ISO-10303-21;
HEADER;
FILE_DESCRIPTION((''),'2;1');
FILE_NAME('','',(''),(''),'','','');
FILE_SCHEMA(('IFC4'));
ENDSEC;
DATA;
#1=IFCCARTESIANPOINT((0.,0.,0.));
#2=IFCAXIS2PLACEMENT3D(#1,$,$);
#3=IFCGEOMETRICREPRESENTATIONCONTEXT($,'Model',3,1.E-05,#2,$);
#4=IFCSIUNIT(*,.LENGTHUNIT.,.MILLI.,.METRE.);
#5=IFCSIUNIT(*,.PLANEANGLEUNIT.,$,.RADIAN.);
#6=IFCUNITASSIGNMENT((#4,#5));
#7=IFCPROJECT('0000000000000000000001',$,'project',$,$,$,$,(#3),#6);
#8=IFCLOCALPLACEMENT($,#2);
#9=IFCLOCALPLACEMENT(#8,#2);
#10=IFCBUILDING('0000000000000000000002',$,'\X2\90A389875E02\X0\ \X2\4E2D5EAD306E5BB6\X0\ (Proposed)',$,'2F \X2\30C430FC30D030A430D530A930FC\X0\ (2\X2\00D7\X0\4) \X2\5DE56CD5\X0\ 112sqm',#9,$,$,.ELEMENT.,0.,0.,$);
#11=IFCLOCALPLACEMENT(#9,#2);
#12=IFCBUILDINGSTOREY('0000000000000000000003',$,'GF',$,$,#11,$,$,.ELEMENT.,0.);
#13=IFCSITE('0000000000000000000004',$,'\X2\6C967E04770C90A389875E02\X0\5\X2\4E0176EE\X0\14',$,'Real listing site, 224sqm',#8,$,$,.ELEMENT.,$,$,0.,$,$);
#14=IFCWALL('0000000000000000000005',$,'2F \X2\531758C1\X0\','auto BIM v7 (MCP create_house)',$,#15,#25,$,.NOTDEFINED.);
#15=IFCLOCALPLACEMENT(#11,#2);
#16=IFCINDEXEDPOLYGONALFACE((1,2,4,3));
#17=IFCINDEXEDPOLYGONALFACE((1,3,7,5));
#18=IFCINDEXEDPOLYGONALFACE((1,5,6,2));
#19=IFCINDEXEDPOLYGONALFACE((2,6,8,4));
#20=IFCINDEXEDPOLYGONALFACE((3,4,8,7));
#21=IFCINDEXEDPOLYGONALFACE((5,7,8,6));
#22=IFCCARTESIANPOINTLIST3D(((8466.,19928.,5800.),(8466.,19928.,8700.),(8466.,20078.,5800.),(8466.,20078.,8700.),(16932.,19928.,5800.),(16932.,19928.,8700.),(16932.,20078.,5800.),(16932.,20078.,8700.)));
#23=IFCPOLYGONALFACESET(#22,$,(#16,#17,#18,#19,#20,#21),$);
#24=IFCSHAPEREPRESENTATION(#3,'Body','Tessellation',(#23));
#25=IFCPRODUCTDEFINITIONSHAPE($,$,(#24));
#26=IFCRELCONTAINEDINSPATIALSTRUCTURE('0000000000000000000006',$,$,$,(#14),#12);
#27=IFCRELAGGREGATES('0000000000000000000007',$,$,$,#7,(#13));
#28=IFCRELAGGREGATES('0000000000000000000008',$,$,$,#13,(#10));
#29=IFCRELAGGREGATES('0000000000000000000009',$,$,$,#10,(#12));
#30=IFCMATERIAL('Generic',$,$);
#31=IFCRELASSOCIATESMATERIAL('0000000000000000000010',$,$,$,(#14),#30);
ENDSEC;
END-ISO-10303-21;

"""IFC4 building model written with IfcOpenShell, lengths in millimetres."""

from ifc_helpers import new_model, si_unit, frame, frame_2d, origin, place, context, project, spatial, rectangle, extrude, material, element, save


model = new_model("IFC4")

# Units and contexts
model_context = context("Model", 3, precision=1e-05, world=origin())
ifc_project = project(units=[si_unit("LENGTHUNIT", "METRE", prefix="MILLI"), si_unit("PLANEANGLEUNIT", "RADIAN")], contexts=[model_context])

# Site, building, storey
site_placement = place(None, origin())
site = spatial("IfcSite", under=ifc_project, at=site_placement, Name="沖縄県那覇市5丁目14", ObjectType="Real listing site, 224sqm", CompositionType="ELEMENT", RefElevation=0.0)
building_placement = place(site_placement, origin())
building = spatial("IfcBuilding", under=site, at=building_placement, Name="那覇市 中庭の家 (Proposed)", ObjectType="2F ツーバイフォー (2×4) 工法 112sqm", CompositionType="ELEMENT", ElevationOfRefHeight=0.0, ElevationOfTerrain=0.0)
storey_placement = place(building_placement, origin())
storey = spatial("IfcBuildingStorey", under=building, at=storey_placement, Name="GF", CompositionType="ELEMENT", Elevation=0.0)

# Shared definitions
ifc_material = material(Name="Generic")

# Wall
wall_1_placement = place(storey_placement, frame((4233.0, 9964.0, 2900.0)))
element("IfcWall", 1, at=wall_1_placement, inside=storey, material=ifc_material, Name="2F 北壁", Description="auto BIM v7 (MCP create_house)", PredefinedType="NOTDEFINED", context=model_context, shape_type="SweptSolid", body=[
    extrude(rectangle(XDim=8466.0, YDim=150.0, at=frame_2d((4233.0, 75.0))), frame((4233.0, 9964.0, 2900.0)), (0.0, 0.0, 1.0), 2900.0),
])

save(model, "model.ifc")
